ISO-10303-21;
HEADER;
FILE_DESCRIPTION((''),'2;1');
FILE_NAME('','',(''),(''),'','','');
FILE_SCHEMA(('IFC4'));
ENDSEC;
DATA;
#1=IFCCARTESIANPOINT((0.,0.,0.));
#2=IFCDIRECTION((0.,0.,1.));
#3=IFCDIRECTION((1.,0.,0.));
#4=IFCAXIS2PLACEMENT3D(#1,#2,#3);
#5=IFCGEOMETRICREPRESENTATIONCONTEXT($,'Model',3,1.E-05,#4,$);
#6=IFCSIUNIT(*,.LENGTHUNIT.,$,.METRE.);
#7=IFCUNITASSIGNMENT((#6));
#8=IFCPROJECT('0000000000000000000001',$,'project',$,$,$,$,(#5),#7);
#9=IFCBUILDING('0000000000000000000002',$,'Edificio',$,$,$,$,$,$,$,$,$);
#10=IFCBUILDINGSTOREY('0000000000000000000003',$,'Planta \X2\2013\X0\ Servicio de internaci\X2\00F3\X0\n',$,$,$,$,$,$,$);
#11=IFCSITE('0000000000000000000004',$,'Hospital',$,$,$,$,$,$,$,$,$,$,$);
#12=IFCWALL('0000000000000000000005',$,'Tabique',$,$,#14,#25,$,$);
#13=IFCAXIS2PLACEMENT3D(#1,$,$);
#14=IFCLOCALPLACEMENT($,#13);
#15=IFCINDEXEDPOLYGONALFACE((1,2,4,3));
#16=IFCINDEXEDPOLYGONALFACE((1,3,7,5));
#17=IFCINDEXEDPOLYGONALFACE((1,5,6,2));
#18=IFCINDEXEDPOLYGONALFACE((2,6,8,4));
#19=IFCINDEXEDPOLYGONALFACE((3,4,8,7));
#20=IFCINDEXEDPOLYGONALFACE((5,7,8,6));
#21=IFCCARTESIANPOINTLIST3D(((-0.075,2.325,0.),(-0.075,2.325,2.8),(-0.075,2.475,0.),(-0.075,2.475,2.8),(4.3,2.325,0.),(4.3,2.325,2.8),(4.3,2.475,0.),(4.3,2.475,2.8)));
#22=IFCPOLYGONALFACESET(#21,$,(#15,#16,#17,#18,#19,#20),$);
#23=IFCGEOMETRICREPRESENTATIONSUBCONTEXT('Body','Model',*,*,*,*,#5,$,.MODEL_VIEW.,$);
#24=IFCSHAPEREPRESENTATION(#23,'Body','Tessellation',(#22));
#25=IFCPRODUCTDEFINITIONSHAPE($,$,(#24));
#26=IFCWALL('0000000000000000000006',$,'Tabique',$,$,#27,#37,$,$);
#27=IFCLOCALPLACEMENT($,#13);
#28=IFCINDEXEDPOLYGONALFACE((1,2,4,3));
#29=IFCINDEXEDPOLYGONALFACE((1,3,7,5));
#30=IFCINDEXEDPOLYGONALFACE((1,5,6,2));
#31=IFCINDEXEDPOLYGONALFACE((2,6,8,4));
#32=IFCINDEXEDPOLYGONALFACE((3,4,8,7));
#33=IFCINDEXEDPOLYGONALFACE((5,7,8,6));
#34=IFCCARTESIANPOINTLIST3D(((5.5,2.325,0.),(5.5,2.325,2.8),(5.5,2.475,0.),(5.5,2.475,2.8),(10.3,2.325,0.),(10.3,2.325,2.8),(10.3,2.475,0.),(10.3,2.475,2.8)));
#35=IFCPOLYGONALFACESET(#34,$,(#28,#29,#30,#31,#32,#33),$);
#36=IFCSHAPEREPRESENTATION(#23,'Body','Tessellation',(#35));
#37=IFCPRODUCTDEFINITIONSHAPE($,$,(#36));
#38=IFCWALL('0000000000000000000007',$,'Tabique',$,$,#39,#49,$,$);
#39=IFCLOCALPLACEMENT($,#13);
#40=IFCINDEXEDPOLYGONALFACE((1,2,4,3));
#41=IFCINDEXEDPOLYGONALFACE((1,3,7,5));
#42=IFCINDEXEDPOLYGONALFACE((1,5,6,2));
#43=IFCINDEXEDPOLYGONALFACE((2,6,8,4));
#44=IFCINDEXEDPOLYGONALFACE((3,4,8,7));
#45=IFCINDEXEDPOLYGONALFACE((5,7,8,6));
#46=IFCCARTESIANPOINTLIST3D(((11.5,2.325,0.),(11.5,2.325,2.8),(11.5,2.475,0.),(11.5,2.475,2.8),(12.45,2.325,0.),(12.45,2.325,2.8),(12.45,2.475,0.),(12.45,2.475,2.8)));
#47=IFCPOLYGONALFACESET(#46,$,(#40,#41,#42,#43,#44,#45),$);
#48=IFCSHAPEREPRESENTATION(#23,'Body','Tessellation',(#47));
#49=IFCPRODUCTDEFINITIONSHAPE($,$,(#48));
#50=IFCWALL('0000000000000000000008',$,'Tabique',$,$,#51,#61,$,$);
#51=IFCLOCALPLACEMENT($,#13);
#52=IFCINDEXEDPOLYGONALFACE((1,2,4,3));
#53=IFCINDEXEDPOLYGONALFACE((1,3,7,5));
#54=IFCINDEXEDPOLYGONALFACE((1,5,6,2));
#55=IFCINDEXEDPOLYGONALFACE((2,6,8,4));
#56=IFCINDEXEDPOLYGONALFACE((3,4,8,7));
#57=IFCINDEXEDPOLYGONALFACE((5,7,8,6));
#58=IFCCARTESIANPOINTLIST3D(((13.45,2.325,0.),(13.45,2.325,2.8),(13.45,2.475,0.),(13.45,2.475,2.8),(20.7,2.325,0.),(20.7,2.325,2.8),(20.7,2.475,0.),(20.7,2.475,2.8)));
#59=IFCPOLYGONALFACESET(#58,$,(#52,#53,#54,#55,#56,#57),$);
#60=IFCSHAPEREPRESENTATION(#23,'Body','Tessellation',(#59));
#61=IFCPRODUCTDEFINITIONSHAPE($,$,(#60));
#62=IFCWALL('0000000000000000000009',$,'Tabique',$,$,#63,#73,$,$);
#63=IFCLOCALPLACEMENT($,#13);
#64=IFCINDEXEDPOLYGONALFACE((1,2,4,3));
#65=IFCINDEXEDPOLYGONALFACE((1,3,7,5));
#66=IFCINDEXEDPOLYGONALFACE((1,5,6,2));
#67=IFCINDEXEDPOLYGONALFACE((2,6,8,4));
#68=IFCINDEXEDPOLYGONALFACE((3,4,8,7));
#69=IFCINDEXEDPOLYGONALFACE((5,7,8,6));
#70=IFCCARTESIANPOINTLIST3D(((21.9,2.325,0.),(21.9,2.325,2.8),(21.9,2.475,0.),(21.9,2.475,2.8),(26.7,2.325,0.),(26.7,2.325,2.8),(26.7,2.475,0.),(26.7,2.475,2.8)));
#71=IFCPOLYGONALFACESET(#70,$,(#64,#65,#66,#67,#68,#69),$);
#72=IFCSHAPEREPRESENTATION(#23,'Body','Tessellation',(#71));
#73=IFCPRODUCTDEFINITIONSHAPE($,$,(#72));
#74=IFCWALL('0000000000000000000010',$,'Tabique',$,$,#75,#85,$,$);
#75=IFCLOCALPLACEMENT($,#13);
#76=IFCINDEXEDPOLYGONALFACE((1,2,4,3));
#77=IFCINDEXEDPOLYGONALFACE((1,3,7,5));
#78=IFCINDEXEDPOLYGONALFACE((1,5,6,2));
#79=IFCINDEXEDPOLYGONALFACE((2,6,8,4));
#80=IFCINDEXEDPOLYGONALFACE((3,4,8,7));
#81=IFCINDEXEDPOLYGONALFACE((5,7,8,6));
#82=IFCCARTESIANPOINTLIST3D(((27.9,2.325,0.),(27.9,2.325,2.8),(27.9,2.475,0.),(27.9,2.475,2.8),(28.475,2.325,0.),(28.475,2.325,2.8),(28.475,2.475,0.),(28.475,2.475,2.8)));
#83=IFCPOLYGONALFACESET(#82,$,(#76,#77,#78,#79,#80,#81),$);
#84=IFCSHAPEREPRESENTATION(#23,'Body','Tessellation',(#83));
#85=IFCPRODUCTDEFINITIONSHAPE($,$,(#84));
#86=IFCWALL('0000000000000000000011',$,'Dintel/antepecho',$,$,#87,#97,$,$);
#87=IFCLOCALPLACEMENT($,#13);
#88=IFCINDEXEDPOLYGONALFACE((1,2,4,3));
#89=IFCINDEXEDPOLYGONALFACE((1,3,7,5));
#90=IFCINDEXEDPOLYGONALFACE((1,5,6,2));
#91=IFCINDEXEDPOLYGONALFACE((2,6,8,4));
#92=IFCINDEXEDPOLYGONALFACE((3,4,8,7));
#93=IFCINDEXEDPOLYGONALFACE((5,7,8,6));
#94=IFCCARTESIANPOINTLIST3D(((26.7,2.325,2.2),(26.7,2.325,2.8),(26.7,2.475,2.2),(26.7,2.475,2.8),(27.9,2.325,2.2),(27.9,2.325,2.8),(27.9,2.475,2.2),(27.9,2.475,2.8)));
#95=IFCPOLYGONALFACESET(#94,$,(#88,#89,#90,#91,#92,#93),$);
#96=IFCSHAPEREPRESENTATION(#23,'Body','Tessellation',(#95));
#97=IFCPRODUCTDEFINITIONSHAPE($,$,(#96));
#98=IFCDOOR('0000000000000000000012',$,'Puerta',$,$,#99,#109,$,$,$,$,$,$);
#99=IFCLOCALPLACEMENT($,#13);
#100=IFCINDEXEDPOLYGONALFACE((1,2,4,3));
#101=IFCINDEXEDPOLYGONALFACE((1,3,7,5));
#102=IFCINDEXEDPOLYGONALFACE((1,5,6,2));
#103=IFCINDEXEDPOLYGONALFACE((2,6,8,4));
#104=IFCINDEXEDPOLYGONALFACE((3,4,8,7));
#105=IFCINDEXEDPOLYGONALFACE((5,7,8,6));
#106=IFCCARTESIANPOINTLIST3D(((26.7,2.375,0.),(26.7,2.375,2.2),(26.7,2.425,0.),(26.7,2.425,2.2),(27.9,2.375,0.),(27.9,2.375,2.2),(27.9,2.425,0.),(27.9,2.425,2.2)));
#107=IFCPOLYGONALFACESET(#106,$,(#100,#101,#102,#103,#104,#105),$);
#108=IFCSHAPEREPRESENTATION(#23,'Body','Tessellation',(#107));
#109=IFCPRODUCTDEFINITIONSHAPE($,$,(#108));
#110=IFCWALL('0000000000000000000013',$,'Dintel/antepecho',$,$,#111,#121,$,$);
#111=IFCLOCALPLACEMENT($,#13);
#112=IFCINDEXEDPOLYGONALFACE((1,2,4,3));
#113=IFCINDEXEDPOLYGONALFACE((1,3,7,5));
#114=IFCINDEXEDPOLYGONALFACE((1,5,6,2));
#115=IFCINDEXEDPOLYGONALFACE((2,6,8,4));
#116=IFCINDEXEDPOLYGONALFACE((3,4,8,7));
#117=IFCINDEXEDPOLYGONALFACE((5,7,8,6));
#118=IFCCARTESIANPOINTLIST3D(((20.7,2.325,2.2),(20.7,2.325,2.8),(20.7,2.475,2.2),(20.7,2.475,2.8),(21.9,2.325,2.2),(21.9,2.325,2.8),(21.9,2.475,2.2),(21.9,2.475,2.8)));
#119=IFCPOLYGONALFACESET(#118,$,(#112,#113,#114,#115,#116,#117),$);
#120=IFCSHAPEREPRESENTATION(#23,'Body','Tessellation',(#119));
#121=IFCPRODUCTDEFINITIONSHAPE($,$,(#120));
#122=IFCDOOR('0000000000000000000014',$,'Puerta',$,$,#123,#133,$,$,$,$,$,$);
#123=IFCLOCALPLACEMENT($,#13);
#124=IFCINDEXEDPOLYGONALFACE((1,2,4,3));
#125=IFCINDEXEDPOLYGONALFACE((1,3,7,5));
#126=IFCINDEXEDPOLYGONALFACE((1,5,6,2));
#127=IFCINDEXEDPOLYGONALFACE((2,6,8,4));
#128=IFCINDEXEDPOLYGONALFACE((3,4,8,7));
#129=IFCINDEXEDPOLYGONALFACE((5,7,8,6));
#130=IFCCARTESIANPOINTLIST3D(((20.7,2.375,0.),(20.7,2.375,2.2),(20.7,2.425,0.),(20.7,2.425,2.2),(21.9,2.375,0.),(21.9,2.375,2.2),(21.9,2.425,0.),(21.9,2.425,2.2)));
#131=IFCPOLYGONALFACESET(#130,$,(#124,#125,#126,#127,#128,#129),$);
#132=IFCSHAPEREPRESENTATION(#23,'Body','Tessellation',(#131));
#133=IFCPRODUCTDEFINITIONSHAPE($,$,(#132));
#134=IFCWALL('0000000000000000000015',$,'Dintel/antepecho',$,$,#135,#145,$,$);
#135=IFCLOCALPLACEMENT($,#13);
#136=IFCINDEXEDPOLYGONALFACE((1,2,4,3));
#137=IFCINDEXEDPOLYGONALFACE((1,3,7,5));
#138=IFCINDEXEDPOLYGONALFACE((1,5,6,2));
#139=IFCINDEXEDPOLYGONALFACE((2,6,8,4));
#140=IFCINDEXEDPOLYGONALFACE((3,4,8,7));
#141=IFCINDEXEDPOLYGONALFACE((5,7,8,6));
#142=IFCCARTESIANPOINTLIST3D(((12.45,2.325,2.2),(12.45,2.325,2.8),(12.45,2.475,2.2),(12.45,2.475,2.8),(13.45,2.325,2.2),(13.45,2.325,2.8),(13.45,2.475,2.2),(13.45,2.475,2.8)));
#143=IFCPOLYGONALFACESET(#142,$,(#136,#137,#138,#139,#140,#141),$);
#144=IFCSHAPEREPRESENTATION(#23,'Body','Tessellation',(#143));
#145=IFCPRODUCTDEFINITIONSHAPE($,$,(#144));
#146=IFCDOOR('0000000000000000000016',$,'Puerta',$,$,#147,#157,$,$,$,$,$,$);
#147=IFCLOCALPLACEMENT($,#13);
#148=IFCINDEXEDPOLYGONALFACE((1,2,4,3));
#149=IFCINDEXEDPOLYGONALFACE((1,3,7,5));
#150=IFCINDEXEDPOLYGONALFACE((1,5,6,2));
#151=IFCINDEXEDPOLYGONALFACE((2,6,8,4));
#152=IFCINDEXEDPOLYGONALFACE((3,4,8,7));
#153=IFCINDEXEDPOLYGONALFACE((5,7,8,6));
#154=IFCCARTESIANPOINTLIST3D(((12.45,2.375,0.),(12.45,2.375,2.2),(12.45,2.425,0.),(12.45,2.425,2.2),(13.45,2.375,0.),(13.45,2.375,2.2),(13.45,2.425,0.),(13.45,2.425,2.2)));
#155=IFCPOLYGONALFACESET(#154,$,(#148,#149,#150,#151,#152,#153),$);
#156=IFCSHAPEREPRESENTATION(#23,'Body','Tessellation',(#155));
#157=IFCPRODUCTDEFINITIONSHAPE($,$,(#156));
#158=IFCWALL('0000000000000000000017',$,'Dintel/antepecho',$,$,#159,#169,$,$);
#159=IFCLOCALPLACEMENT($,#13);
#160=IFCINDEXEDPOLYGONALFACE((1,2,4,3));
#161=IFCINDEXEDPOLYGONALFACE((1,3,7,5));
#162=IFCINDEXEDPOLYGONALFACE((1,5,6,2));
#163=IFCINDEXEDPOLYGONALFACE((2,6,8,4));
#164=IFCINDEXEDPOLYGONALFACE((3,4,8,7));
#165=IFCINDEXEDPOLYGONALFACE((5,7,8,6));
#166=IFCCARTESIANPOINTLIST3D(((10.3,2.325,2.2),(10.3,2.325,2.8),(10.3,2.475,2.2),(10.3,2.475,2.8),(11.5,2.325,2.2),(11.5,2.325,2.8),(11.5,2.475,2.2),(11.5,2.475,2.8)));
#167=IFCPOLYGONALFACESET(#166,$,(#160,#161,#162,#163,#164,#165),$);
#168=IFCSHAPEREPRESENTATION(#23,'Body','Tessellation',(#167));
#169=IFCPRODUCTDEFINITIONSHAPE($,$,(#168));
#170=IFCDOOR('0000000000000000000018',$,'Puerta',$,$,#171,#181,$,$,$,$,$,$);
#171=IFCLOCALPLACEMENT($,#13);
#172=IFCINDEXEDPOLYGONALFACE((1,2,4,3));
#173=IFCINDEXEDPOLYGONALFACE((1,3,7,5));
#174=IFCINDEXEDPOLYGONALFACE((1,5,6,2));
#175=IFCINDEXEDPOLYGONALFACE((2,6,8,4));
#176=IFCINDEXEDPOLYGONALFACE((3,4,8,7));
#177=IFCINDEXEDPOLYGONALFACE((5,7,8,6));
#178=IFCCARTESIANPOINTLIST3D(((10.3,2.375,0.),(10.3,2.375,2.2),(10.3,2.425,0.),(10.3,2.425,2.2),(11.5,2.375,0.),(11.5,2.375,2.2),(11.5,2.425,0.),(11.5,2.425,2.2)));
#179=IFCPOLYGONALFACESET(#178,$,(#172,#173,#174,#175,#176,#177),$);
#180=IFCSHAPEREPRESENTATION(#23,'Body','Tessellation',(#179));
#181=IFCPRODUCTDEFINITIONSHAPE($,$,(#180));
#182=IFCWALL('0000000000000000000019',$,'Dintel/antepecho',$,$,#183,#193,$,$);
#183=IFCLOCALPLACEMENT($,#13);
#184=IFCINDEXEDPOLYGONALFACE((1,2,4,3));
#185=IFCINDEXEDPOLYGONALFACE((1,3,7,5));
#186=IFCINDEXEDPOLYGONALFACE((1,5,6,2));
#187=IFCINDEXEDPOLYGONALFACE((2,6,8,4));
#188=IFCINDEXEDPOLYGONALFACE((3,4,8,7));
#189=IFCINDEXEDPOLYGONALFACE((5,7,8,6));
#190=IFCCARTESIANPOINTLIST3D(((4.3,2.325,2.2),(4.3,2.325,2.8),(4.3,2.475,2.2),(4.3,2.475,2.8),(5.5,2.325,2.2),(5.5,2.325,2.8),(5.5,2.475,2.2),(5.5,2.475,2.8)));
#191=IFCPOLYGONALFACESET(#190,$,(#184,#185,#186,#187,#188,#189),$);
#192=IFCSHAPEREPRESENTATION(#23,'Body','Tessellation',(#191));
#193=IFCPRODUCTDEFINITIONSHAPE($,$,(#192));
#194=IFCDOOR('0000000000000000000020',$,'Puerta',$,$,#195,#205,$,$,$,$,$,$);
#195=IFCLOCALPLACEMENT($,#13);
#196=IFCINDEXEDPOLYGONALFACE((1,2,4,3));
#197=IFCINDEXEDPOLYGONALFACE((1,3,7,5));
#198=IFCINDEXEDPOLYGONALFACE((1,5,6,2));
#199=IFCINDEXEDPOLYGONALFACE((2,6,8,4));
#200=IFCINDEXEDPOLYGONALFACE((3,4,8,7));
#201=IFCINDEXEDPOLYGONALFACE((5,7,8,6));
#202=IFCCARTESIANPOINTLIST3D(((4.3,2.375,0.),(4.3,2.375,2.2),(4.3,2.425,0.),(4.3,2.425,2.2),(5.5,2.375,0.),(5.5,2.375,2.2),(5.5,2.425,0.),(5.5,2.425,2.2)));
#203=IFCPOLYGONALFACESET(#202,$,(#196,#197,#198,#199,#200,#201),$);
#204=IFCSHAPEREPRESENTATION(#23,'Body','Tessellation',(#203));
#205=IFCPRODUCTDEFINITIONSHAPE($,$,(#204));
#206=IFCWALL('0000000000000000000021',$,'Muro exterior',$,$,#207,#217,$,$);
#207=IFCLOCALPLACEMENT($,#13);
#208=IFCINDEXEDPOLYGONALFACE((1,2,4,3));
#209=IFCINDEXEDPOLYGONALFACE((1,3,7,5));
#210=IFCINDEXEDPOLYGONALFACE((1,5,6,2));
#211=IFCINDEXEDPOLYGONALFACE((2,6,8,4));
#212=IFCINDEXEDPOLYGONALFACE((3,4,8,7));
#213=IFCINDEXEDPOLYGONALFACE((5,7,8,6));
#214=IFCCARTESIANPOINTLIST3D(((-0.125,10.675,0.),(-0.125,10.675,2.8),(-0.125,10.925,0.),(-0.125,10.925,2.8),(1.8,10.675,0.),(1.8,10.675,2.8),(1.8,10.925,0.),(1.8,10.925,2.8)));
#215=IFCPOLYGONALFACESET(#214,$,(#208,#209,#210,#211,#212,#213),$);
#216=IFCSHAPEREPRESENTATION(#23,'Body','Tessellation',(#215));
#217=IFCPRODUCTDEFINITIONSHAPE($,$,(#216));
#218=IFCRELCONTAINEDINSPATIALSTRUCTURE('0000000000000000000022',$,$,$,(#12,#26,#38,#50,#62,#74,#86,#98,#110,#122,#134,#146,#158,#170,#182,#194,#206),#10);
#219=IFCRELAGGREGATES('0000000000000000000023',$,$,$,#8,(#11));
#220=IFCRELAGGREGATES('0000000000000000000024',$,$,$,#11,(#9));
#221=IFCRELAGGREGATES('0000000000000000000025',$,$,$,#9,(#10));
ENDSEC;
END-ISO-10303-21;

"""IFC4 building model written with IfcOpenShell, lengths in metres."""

from ifc_helpers import new_model, si_unit, frame, origin_with_axes, context, subcontext, project, spatial, line, indexed_curve, outline, extrude, element, save


model = new_model("IFC4")

# Units and contexts
model_context = context("Model", 3, precision=1e-05, world=origin_with_axes())
body_context = subcontext(model_context, "Body", "Model", "MODEL_VIEW")
ifc_project = project(units=[si_unit("LENGTHUNIT", "METRE")], contexts=[model_context])

# Site, building, storey
site = spatial("IfcSite", under=ifc_project, Name="Hospital")
building = spatial("IfcBuilding", under=site, Name="Edificio")
storey = spatial("IfcBuildingStorey", under=building, Name="Planta – Servicio de internación")

# Walls
element("IfcWall", 1, inside=storey, Name="Tabique", context=body_context, shape_type="SweptSolid", body=[
    extrude(outline(indexed_curve([(0.0, 0.0), (4.375, 0.0), (4.375, 0.15), (0.0, 0.15)], segments=[line(1, 2, 3, 4, 1)])), frame((-0.075, 2.325, 0.0), z_axis=(0.0, 0.0, 1.0), x_axis=(1.0, 0.0, 0.0)), (0.0, 0.0, 1.0), 2.8),
])
element("IfcWall", 2, inside=storey, Name="Tabique", context=body_context, shape_type="SweptSolid", body=[
    extrude(outline(indexed_curve([(0.0, 0.0), (4.8, 0.0), (4.8, 0.15), (0.0, 0.15)], segments=[line(1, 2, 3, 4, 1)])), frame((5.5, 2.325, 0.0), z_axis=(0.0, 0.0, 1.0), x_axis=(1.0, 0.0, 0.0)), (0.0, 0.0, 1.0), 2.8),
])
element("IfcWall", 3, inside=storey, Name="Tabique", context=body_context, shape_type="SweptSolid", body=[
    extrude(outline(indexed_curve([(0.0, 0.0), (0.95, 0.0), (0.95, 0.15), (0.0, 0.15)], segments=[line(1, 2, 3, 4, 1)])), frame((11.5, 2.325, 0.0), z_axis=(0.0, 0.0, 1.0), x_axis=(1.0, 0.0, 0.0)), (0.0, 0.0, 1.0), 2.8),
])
element("IfcWall", 4, inside=storey, Name="Tabique", context=body_context, shape_type="SweptSolid", body=[
    extrude(outline(indexed_curve([(0.0, 0.0), (7.25, 0.0), (7.25, 0.15), (0.0, 0.15)], segments=[line(1, 2, 3, 4, 1)])), frame((13.45, 2.325, 0.0), z_axis=(0.0, 0.0, 1.0), x_axis=(1.0, 0.0, 0.0)), (0.0, 0.0, 1.0), 2.8),
])
element("IfcWall", 5, inside=storey, Name="Tabique", context=body_context, shape_type="SweptSolid", body=[
    extrude(outline(indexed_curve([(0.0, 0.0), (4.8, 0.0), (4.8, 0.15), (0.0, 0.15)], segments=[line(1, 2, 3, 4, 1)])), frame((21.9, 2.325, 0.0), z_axis=(0.0, 0.0, 1.0), x_axis=(1.0, 0.0, 0.0)), (0.0, 0.0, 1.0), 2.8),
])
element("IfcWall", 6, inside=storey, Name="Tabique", context=body_context, shape_type="SweptSolid", body=[
    extrude(outline(indexed_curve([(0.0, 0.0), (0.575, 0.0), (0.575, 0.15), (0.0, 0.15)], segments=[line(1, 2, 3, 4, 1)])), frame((27.9, 2.325, 0.0), z_axis=(0.0, 0.0, 1.0), x_axis=(1.0, 0.0, 0.0)), (0.0, 0.0, 1.0), 2.8),
])
element("IfcWall", 7, inside=storey, Name="Dintel/antepecho", context=body_context, shape_type="SweptSolid", body=[
    extrude(outline(indexed_curve([(0.0, 0.0), (1.2, 0.0), (1.2, 0.15), (0.0, 0.15)], segments=[line(1, 2, 3, 4, 1)])), frame((26.7, 2.325, 2.2), z_axis=(0.0, 0.0, 1.0), x_axis=(1.0, 0.0, 0.0)), (0.0, 0.0, 1.0), 0.6),
])

# Door
element("IfcDoor", 8, inside=storey, Name="Puerta", context=body_context, shape_type="SweptSolid", body=[
    extrude(outline(indexed_curve([(0.0, 0.0), (1.2, 0.0), (1.2, 0.05), (0.0, 0.05)], segments=[line(1, 2, 3, 4, 1)])), frame((26.7, 2.375, 0.0), z_axis=(0.0, 0.0, 1.0), x_axis=(1.0, 0.0, 0.0)), (0.0, 0.0, 1.0), 2.2),
])

# Wall
element("IfcWall", 9, inside=storey, Name="Dintel/antepecho", context=body_context, shape_type="SweptSolid", body=[
    extrude(outline(indexed_curve([(0.0, 0.0), (1.2, 0.0), (1.2, 0.15), (0.0, 0.15)], segments=[line(1, 2, 3, 4, 1)])), frame((20.7, 2.325, 2.2), z_axis=(0.0, 0.0, 1.0), x_axis=(1.0, 0.0, 0.0)), (0.0, 0.0, 1.0), 0.6),
])

# Door
element("IfcDoor", 10, inside=storey, Name="Puerta", context=body_context, shape_type="SweptSolid", body=[
    extrude(outline(indexed_curve([(0.0, 0.0), (1.2, 0.0), (1.2, 0.05), (0.0, 0.05)], segments=[line(1, 2, 3, 4, 1)])), frame((20.7, 2.375, 0.0), z_axis=(0.0, 0.0, 1.0), x_axis=(1.0, 0.0, 0.0)), (0.0, 0.0, 1.0), 2.2),
])

# Wall
element("IfcWall", 11, inside=storey, Name="Dintel/antepecho", context=body_context, shape_type="SweptSolid", body=[
    extrude(outline(indexed_curve([(0.0, 0.0), (1.0, 0.0), (1.0, 0.15), (0.0, 0.15)], segments=[line(1, 2, 3, 4, 1)])), frame((12.45, 2.325, 2.2), z_axis=(0.0, 0.0, 1.0), x_axis=(1.0, 0.0, 0.0)), (0.0, 0.0, 1.0), 0.6),
])

# Door
element("IfcDoor", 12, inside=storey, Name="Puerta", context=body_context, shape_type="SweptSolid", body=[
    extrude(outline(indexed_curve([(0.0, 0.0), (1.0, 0.0), (1.0, 0.05), (0.0, 0.05)], segments=[line(1, 2, 3, 4, 1)])), frame((12.45, 2.375, 0.0), z_axis=(0.0, 0.0, 1.0), x_axis=(1.0, 0.0, 0.0)), (0.0, 0.0, 1.0), 2.2),
])

# Wall
element("IfcWall", 13, inside=storey, Name="Dintel/antepecho", context=body_context, shape_type="SweptSolid", body=[
    extrude(outline(indexed_curve([(0.0, 0.0), (1.2, 0.0), (1.2, 0.15), (0.0, 0.15)], segments=[line(1, 2, 3, 4, 1)])), frame((10.3, 2.325, 2.2), z_axis=(0.0, 0.0, 1.0), x_axis=(1.0, 0.0, 0.0)), (0.0, 0.0, 1.0), 0.6),
])

# Door
element("IfcDoor", 14, inside=storey, Name="Puerta", context=body_context, shape_type="SweptSolid", body=[
    extrude(outline(indexed_curve([(0.0, 0.0), (1.2, 0.0), (1.2, 0.05), (0.0, 0.05)], segments=[line(1, 2, 3, 4, 1)])), frame((10.3, 2.375, 0.0), z_axis=(0.0, 0.0, 1.0), x_axis=(1.0, 0.0, 0.0)), (0.0, 0.0, 1.0), 2.2),
])

# Wall
element("IfcWall", 15, inside=storey, Name="Dintel/antepecho", context=body_context, shape_type="SweptSolid", body=[
    extrude(outline(indexed_curve([(0.0, 0.0), (1.2, 0.0), (1.2, 0.15), (0.0, 0.15)], segments=[line(1, 2, 3, 4, 1)])), frame((4.3, 2.325, 2.2), z_axis=(0.0, 0.0, 1.0), x_axis=(1.0, 0.0, 0.0)), (0.0, 0.0, 1.0), 0.6),
])

# Door
element("IfcDoor", 16, inside=storey, Name="Puerta", context=body_context, shape_type="SweptSolid", body=[
    extrude(outline(indexed_curve([(0.0, 0.0), (1.2, 0.0), (1.2, 0.05), (0.0, 0.05)], segments=[line(1, 2, 3, 4, 1)])), frame((4.3, 2.375, 0.0), z_axis=(0.0, 0.0, 1.0), x_axis=(1.0, 0.0, 0.0)), (0.0, 0.0, 1.0), 2.2),
])

# Wall
element("IfcWall", 17, inside=storey, Name="Muro exterior", context=body_context, shape_type="SweptSolid", body=[
    extrude(outline(indexed_curve([(0.0, 0.0), (1.925, 0.0), (1.925, 0.25), (0.0, 0.25)], segments=[line(1, 2, 3, 4, 1)])), frame((-0.125, 10.675, 0.0), z_axis=(0.0, 0.0, 1.0), x_axis=(1.0, 0.0, 0.0)), (0.0, 0.0, 1.0), 2.8),
])

save(model, "model.ifc")
